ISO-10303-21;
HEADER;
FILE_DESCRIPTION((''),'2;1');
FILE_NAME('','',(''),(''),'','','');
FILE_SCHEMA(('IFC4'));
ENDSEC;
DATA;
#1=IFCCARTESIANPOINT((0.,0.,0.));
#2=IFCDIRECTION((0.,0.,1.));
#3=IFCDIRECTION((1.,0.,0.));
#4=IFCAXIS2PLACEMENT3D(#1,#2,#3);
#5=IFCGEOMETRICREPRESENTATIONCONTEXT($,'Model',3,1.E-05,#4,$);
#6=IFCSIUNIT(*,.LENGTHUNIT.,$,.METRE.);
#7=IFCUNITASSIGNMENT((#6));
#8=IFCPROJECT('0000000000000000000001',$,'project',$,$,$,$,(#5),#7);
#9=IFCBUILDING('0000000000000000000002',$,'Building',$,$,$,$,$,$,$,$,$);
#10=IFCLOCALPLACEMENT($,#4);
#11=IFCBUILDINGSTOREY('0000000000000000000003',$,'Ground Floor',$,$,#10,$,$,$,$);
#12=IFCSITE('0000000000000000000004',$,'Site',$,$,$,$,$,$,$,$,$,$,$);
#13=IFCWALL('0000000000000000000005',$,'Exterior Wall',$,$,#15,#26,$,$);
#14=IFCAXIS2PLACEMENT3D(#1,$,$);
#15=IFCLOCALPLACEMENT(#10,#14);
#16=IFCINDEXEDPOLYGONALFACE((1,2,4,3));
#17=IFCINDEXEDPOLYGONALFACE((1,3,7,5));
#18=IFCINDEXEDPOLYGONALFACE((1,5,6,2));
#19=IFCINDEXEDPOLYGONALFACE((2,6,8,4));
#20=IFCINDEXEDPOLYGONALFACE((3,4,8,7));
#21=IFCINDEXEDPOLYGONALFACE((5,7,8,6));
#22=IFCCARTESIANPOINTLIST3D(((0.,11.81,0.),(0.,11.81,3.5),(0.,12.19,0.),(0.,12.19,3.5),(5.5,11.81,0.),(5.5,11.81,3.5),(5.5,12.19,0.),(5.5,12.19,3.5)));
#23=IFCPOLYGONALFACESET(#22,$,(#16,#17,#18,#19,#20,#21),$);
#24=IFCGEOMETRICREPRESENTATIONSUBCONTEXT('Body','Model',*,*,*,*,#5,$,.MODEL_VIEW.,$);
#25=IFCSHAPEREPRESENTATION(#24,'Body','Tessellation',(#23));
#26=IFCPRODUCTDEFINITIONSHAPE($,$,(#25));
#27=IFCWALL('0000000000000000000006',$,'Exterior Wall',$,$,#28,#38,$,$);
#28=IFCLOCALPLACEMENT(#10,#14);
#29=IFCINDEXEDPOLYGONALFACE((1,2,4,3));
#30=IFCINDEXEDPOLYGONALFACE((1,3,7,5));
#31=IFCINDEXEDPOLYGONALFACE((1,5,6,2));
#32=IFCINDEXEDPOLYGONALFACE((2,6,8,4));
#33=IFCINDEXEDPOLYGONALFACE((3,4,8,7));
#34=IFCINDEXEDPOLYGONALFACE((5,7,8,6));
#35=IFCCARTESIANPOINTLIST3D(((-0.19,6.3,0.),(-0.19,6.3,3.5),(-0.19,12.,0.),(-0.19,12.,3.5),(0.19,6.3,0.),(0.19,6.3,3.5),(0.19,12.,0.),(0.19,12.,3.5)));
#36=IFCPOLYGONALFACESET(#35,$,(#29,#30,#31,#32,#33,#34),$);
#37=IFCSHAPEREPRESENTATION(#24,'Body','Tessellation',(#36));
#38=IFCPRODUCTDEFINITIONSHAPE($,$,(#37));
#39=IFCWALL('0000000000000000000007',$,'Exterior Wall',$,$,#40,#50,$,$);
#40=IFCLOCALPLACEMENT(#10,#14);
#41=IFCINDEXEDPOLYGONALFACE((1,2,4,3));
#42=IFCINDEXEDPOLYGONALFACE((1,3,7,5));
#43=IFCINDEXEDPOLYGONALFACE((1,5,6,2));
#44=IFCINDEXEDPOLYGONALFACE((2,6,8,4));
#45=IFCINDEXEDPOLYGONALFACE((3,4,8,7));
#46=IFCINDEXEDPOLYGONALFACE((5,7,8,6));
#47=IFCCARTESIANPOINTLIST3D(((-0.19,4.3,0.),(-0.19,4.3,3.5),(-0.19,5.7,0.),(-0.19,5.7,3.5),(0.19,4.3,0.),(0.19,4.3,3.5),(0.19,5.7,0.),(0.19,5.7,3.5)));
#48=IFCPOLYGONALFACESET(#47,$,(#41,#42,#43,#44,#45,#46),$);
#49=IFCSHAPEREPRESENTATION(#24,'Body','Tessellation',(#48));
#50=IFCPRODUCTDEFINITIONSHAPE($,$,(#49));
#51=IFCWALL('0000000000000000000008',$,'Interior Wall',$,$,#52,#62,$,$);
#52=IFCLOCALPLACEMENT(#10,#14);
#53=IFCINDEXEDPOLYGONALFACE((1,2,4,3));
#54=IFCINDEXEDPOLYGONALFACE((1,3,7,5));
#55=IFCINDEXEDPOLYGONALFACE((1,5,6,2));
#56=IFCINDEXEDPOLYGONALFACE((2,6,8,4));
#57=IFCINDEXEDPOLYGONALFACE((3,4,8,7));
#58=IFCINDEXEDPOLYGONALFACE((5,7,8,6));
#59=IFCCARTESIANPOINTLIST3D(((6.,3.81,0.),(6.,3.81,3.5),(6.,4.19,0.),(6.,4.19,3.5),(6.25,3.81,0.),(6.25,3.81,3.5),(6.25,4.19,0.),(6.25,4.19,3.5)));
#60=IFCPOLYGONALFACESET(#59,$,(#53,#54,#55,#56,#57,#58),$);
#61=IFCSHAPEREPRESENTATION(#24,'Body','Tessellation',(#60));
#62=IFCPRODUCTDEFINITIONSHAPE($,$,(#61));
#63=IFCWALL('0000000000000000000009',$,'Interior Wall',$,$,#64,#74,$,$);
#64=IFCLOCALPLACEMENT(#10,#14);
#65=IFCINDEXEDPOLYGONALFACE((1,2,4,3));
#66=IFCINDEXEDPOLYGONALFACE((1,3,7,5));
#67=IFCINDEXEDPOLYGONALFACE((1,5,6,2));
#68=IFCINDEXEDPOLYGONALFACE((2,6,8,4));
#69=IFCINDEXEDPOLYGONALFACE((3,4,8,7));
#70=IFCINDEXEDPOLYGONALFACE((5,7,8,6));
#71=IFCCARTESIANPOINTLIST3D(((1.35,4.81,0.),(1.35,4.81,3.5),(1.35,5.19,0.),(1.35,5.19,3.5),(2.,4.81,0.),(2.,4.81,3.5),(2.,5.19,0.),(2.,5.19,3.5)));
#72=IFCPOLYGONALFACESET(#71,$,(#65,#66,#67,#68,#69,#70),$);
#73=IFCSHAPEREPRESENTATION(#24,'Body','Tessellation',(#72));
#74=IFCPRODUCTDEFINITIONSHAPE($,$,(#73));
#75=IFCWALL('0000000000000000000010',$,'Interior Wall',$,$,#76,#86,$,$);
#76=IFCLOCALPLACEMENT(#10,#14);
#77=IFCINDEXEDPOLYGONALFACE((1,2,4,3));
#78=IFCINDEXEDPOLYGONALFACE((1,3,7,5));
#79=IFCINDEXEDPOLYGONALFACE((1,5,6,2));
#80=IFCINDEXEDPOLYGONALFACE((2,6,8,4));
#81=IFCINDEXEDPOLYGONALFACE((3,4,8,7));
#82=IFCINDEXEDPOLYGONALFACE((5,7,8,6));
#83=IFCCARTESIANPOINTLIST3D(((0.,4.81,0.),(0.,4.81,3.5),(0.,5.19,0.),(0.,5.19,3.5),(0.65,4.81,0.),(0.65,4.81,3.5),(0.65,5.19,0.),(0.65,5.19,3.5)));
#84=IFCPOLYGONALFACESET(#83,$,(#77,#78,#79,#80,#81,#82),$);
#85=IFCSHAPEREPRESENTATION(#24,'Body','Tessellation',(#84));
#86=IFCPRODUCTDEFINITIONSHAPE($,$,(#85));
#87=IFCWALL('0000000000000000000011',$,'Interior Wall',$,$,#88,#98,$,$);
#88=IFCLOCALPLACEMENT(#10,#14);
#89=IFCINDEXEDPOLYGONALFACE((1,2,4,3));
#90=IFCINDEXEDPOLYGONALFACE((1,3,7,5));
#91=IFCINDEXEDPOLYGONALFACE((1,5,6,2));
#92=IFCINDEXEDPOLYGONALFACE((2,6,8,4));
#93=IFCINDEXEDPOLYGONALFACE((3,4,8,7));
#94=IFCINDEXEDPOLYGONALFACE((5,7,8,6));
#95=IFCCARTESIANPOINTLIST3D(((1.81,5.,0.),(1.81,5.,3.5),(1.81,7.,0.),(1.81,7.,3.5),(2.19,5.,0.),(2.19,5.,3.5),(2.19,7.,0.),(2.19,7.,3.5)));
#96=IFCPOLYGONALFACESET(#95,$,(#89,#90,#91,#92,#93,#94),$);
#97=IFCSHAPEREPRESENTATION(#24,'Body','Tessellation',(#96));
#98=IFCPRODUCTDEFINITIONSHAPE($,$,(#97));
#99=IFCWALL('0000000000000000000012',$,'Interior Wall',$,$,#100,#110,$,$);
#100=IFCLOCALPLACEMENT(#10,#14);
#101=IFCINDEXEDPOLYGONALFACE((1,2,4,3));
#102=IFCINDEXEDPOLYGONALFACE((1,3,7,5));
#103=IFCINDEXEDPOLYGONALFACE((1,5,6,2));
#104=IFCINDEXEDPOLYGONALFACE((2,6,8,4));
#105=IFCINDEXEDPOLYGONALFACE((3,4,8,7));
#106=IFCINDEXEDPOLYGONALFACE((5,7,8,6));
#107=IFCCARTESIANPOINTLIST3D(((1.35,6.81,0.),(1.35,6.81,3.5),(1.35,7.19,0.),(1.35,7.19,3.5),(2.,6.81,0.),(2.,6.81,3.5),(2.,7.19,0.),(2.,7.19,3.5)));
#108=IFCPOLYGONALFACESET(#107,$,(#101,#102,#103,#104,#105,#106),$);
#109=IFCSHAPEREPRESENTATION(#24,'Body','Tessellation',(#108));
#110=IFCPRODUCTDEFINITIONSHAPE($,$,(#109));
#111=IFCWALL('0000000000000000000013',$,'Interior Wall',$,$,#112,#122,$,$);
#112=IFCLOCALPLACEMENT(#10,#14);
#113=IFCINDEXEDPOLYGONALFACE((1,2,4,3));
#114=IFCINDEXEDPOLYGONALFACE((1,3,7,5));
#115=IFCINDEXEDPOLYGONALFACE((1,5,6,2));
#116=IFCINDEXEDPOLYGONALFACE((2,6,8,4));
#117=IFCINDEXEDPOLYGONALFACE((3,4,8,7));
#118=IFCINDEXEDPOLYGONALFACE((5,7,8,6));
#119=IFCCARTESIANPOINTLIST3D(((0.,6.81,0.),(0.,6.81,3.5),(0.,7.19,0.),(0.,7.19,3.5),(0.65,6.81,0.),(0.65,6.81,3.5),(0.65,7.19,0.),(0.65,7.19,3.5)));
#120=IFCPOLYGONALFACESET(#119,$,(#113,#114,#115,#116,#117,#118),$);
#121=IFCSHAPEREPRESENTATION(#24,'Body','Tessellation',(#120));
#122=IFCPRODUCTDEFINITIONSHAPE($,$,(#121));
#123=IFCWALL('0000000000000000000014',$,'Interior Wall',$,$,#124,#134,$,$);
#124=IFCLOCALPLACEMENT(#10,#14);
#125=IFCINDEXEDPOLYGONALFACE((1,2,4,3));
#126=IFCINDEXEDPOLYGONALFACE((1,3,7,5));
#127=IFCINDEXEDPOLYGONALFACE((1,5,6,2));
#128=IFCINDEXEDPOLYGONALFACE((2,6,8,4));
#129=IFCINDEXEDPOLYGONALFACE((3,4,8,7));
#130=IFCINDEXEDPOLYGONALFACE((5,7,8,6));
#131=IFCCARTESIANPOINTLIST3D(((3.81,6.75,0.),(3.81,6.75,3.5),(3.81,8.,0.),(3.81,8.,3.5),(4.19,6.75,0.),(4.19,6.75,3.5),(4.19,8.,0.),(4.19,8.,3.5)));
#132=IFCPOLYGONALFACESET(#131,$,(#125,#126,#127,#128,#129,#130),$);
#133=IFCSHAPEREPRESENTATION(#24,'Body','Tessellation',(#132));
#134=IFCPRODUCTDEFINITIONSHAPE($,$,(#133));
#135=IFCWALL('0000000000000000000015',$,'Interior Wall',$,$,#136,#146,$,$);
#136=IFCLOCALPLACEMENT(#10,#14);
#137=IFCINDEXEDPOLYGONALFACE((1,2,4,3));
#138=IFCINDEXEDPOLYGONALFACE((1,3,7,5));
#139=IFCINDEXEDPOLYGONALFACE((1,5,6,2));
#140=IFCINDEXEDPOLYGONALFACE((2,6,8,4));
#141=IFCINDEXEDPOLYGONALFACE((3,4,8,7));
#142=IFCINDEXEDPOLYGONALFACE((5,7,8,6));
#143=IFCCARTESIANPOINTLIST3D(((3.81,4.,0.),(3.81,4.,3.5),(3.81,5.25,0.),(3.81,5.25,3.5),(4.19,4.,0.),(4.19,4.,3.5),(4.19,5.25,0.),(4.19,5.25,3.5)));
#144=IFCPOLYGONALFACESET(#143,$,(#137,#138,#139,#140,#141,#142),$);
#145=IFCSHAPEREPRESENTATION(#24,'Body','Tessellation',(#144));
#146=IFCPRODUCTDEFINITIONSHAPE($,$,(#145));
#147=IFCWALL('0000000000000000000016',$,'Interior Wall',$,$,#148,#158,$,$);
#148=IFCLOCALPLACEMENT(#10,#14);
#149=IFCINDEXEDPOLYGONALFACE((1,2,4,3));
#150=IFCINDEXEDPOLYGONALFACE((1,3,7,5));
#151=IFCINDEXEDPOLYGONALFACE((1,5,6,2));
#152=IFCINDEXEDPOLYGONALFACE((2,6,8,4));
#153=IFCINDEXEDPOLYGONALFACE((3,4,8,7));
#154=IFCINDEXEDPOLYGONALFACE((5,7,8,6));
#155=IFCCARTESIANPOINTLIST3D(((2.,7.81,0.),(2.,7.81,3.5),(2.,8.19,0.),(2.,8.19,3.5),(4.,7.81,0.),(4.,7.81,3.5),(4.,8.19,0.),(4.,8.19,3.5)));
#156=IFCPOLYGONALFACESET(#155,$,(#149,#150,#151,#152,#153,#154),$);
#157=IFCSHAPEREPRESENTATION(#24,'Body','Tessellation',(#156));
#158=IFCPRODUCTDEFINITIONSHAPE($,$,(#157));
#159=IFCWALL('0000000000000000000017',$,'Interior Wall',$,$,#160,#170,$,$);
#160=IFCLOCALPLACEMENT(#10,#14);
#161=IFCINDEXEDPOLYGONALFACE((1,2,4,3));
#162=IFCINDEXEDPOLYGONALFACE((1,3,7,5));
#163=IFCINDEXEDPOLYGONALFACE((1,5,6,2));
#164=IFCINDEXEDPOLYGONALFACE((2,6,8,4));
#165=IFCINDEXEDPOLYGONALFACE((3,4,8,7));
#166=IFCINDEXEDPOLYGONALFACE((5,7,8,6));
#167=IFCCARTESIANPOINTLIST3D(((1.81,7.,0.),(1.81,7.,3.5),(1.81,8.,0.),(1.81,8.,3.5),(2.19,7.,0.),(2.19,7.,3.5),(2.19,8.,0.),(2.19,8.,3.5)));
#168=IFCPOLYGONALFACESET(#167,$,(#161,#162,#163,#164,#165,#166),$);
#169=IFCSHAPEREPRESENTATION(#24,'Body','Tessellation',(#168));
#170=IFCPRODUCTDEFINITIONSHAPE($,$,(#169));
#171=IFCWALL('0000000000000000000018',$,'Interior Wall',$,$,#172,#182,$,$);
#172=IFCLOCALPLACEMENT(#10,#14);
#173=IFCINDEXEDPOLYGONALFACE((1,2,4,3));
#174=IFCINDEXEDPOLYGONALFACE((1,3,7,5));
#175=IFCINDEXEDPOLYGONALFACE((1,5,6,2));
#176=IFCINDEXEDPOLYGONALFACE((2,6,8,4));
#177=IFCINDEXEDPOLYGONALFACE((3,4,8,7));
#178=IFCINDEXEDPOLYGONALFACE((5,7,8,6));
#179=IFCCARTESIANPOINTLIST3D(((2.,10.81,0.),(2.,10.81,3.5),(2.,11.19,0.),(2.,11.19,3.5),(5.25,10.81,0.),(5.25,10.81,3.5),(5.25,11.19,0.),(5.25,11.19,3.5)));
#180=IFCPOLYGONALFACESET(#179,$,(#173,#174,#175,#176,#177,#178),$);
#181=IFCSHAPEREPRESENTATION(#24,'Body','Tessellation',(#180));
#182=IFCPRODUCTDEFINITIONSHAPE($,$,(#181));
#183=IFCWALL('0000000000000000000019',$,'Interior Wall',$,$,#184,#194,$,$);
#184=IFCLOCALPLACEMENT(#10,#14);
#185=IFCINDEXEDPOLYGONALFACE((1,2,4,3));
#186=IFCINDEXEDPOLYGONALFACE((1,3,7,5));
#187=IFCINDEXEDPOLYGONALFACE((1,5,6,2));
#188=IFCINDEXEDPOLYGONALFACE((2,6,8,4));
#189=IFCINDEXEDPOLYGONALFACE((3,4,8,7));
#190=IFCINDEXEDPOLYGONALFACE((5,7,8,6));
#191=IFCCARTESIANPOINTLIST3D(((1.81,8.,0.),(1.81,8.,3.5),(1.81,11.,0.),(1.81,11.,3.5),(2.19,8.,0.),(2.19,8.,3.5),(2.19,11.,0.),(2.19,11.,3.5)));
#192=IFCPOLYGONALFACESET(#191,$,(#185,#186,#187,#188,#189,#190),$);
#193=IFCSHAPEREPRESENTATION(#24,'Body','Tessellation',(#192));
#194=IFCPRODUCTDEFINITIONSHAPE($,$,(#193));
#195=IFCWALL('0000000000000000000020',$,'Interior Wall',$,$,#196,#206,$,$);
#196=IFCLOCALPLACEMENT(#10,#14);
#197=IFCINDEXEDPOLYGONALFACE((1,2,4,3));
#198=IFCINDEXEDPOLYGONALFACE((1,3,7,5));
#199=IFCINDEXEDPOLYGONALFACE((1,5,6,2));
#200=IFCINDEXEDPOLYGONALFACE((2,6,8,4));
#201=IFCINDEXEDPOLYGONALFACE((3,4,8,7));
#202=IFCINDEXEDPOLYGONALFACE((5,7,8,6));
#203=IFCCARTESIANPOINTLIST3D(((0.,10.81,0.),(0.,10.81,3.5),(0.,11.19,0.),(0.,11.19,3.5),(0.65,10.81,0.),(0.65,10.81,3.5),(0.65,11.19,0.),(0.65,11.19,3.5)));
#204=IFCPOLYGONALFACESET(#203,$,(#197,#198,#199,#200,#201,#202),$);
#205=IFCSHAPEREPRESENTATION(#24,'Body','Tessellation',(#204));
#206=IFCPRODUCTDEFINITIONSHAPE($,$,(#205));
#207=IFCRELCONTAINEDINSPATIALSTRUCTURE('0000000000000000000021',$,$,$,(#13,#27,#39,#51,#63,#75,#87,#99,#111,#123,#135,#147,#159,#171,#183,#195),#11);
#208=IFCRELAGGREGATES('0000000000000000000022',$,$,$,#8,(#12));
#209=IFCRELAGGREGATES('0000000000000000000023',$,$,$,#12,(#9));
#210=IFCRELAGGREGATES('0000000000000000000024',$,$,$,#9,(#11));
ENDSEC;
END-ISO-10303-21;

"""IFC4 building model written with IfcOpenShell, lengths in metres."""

from ifc_helpers import new_model, si_unit, frame, origin_with_axes, place, context, subcontext, project, spatial, indexed_curve, outline, extrude, element, save


model = new_model("IFC4")

# Units and contexts
model_context = context("Model", 3, precision=1e-05, world=origin_with_axes())
body_context = subcontext(model_context, "Body", "Model", "MODEL_VIEW")
ifc_project = project(units=[si_unit("LENGTHUNIT", "METRE")], contexts=[model_context])

# Site, building, storey
site = spatial("IfcSite", under=ifc_project, Name="Site")
building = spatial("IfcBuilding", under=site, Name="Building")
storey_placement = place(None, origin_with_axes())
storey = spatial("IfcBuildingStorey", under=building, at=storey_placement, Name="Ground Floor")

# Walls
wall_1_placement = place(storey_placement, frame((5.5, 12.0, 0.0), z_axis=(0.0, 0.0, 1.0), x_axis=(-1.0, 0.0, 0.0)))
element("IfcWall", 1, at=wall_1_placement, inside=storey, Name="Exterior Wall", context=body_context, shape_type="SweptSolid", body=[
    extrude(outline(indexed_curve([(0.0, 0.0), (0.0, 0.38), (5.5, 0.38), (5.5, 0.0), (0.0, 0.0)], self_intersect=False)), frame((0.0, -0.19, 0.0), z_axis=(0.0, 0.0, 1.0), x_axis=(1.0, 0.0, 0.0)), (0.0, 0.0, 1.0), 3.5),
])
wall_2_placement = place(storey_placement, frame((0.0, 12.0, 0.0), z_axis=(0.0, 0.0, 1.0), x_axis=(0.0, -1.0, 0.0)))
element("IfcWall", 2, at=wall_2_placement, inside=storey, Name="Exterior Wall", context=body_context, shape_type="SweptSolid", body=[
    extrude(outline(indexed_curve([(0.0, 0.0), (0.0, 0.38), (5.7, 0.38), (5.7, 0.0), (0.0, 0.0)], self_intersect=False)), frame((0.0, -0.19, 0.0), z_axis=(0.0, 0.0, 1.0), x_axis=(1.0, 0.0, 0.0)), (0.0, 0.0, 1.0), 3.5),
])
wall_3_placement = place(storey_placement, frame((0.0, 5.7, 0.0), z_axis=(0.0, 0.0, 1.0), x_axis=(0.0, -1.0, 0.0)))
element("IfcWall", 3, at=wall_3_placement, inside=storey, Name="Exterior Wall", context=body_context, shape_type="SweptSolid", body=[
    extrude(outline(indexed_curve([(0.0, 0.0), (0.0, 0.38), (1.4, 0.38), (1.4, 0.0), (0.0, 0.0)], self_intersect=False)), frame((0.0, -0.19, 0.0), z_axis=(0.0, 0.0, 1.0), x_axis=(1.0, 0.0, 0.0)), (0.0, 0.0, 1.0), 3.5),
])
wall_4_placement = place(storey_placement, frame((6.25, 4.0, 0.0), z_axis=(0.0, 0.0, 1.0), x_axis=(-1.0, 0.0, 0.0)))
element("IfcWall", 4, at=wall_4_placement, inside=storey, Name="Interior Wall", context=body_context, shape_type="SweptSolid", body=[
    extrude(outline(indexed_curve([(0.0, 0.0), (0.0, 0.38), (0.25, 0.38), (0.25, 0.0), (0.0, 0.0)], self_intersect=False)), frame((0.0, -0.19, 0.0), z_axis=(0.0, 0.0, 1.0), x_axis=(1.0, 0.0, 0.0)), (0.0, 0.0, 1.0), 3.5),
])
for number, where, z_axis, x_axis, name in (
    (5, (2.0, 5.0, 0.0), (0.0, 0.0, 1.0), (-1.0, 0.0, 0.0), "Interior Wall"),
    (6, (0.65, 5.0, 0.0), (0.0, 0.0, 1.0), (-1.0, 0.0, 0.0), "Interior Wall"),
):
    element("IfcWall", number, at=place(storey_placement, frame(where, z_axis=z_axis, x_axis=x_axis)), inside=storey, Name=name, context=body_context, shape_type="SweptSolid", body=[
        extrude(outline(indexed_curve([(0.0, 0.0), (0.0, 0.38), (0.65, 0.38), (0.65, 0.0), (0.0, 0.0)], self_intersect=False)), frame((0.0, -0.19, 0.0), z_axis=(0.0, 0.0, 1.0), x_axis=(1.0, 0.0, 0.0)), (0.0, 0.0, 1.0), 3.5),
    ])
wall_5_placement = place(storey_placement, frame((2.0, 5.0, 0.0), z_axis=(0.0, 0.0, 1.0), x_axis=(0.0, 1.0, 0.0)))
element("IfcWall", 7, at=wall_5_placement, inside=storey, Name="Interior Wall", context=body_context, shape_type="SweptSolid", body=[
    extrude(outline(indexed_curve([(0.0, 0.0), (0.0, 0.38), (2.0, 0.38), (2.0, 0.0), (0.0, 0.0)], self_intersect=False)), frame((0.0, -0.19, 0.0), z_axis=(0.0, 0.0, 1.0), x_axis=(1.0, 0.0, 0.0)), (0.0, 0.0, 1.0), 3.5),
])
for number, where, z_axis, x_axis, name in (
    (8, (2.0, 7.0, 0.0), (0.0, 0.0, 1.0), (-1.0, 0.0, 0.0), "Interior Wall"),
    (9, (0.65, 7.0, 0.0), (0.0, 0.0, 1.0), (-1.0, 0.0, 0.0), "Interior Wall"),
):
    element("IfcWall", number, at=place(storey_placement, frame(where, z_axis=z_axis, x_axis=x_axis)), inside=storey, Name=name, context=body_context, shape_type="SweptSolid", body=[
        extrude(outline(indexed_curve([(0.0, 0.0), (0.0, 0.38), (0.65, 0.38), (0.65, 0.0), (0.0, 0.0)], self_intersect=False)), frame((0.0, -0.19, 0.0), z_axis=(0.0, 0.0, 1.0), x_axis=(1.0, 0.0, 0.0)), (0.0, 0.0, 1.0), 3.5),
    ])
for number, where, z_axis, x_axis, name in (
    (10, (4.0, 8.0, 0.0), (0.0, 0.0, 1.0), (0.0, -1.0, 0.0), "Interior Wall"),
    (11, (4.0, 5.25, 0.0), (0.0, 0.0, 1.0), (0.0, -1.0, 0.0), "Interior Wall"),
):
    element("IfcWall", number, at=place(storey_placement, frame(where, z_axis=z_axis, x_axis=x_axis)), inside=storey, Name=name, context=body_context, shape_type="SweptSolid", body=[
        extrude(outline(indexed_curve([(0.0, 0.0), (0.0, 0.38), (1.25, 0.38), (1.25, 0.0), (0.0, 0.0)], self_intersect=False)), frame((0.0, -0.19, 0.0), z_axis=(0.0, 0.0, 1.0), x_axis=(1.0, 0.0, 0.0)), (0.0, 0.0, 1.0), 3.5),
    ])
wall_6_placement = place(storey_placement, frame((4.0, 8.0, 0.0), z_axis=(0.0, 0.0, 1.0), x_axis=(-1.0, 0.0, 0.0)))
element("IfcWall", 12, at=wall_6_placement, inside=storey, Name="Interior Wall", context=body_context, shape_type="SweptSolid", body=[
    extrude(outline(indexed_curve([(0.0, 0.0), (0.0, 0.38), (2.0, 0.38), (2.0, 0.0), (0.0, 0.0)], self_intersect=False)), frame((0.0, -0.19, 0.0), z_axis=(0.0, 0.0, 1.0), x_axis=(1.0, 0.0, 0.0)), (0.0, 0.0, 1.0), 3.5),
])
wall_7_placement = place(storey_placement, frame((2.0, 8.0, 0.0), z_axis=(0.0, 0.0, 1.0), x_axis=(0.0, -1.0, 0.0)))
element("IfcWall", 13, at=wall_7_placement, inside=storey, Name="Interior Wall", context=body_context, shape_type="SweptSolid", body=[
    extrude(outline(indexed_curve([(0.0, 0.0), (0.0, 0.38), (1.0, 0.38), (1.0, 0.0), (0.0, 0.0)], self_intersect=False)), frame((0.0, -0.19, 0.0), z_axis=(0.0, 0.0, 1.0), x_axis=(1.0, 0.0, 0.0)), (0.0, 0.0, 1.0), 3.5),
])
wall_8_placement = place(storey_placement, frame((5.25, 11.0, 0.0), z_axis=(0.0, 0.0, 1.0), x_axis=(-1.0, 0.0, 0.0)))
element("IfcWall", 14, at=wall_8_placement, inside=storey, Name="Interior Wall", context=body_context, shape_type="SweptSolid", body=[
    extrude(outline(indexed_curve([(0.0, 0.0), (0.0, 0.38), (3.25, 0.38), (3.25, 0.0), (0.0, 0.0)], self_intersect=False)), frame((0.0, -0.19, 0.0), z_axis=(0.0, 0.0, 1.0), x_axis=(1.0, 0.0, 0.0)), (0.0, 0.0, 1.0), 3.5),
])
wall_9_placement = place(storey_placement, frame((2.0, 11.0, 0.0), z_axis=(0.0, 0.0, 1.0), x_axis=(0.0, -1.0, 0.0)))
element("IfcWall", 15, at=wall_9_placement, inside=storey, Name="Interior Wall", context=body_context, shape_type="SweptSolid", body=[
    extrude(outline(indexed_curve([(0.0, 0.0), (0.0, 0.38), (3.0, 0.38), (3.0, 0.0), (0.0, 0.0)], self_intersect=False)), frame((0.0, -0.19, 0.0), z_axis=(0.0, 0.0, 1.0), x_axis=(1.0, 0.0, 0.0)), (0.0, 0.0, 1.0), 3.5),
])
wall_10_placement = place(storey_placement, frame((0.0, 11.0, 0.0), z_axis=(0.0, 0.0, 1.0), x_axis=(1.0, 0.0, 0.0)))
element("IfcWall", 16, at=wall_10_placement, inside=storey, Name="Interior Wall", context=body_context, shape_type="SweptSolid", body=[
    extrude(outline(indexed_curve([(0.0, 0.0), (0.0, 0.38), (0.65, 0.38), (0.65, 0.0), (0.0, 0.0)], self_intersect=False)), frame((0.0, -0.19, 0.0), z_axis=(0.0, 0.0, 1.0), x_axis=(1.0, 0.0, 0.0)), (0.0, 0.0, 1.0), 3.5),
])

save(model, "model.ifc")
